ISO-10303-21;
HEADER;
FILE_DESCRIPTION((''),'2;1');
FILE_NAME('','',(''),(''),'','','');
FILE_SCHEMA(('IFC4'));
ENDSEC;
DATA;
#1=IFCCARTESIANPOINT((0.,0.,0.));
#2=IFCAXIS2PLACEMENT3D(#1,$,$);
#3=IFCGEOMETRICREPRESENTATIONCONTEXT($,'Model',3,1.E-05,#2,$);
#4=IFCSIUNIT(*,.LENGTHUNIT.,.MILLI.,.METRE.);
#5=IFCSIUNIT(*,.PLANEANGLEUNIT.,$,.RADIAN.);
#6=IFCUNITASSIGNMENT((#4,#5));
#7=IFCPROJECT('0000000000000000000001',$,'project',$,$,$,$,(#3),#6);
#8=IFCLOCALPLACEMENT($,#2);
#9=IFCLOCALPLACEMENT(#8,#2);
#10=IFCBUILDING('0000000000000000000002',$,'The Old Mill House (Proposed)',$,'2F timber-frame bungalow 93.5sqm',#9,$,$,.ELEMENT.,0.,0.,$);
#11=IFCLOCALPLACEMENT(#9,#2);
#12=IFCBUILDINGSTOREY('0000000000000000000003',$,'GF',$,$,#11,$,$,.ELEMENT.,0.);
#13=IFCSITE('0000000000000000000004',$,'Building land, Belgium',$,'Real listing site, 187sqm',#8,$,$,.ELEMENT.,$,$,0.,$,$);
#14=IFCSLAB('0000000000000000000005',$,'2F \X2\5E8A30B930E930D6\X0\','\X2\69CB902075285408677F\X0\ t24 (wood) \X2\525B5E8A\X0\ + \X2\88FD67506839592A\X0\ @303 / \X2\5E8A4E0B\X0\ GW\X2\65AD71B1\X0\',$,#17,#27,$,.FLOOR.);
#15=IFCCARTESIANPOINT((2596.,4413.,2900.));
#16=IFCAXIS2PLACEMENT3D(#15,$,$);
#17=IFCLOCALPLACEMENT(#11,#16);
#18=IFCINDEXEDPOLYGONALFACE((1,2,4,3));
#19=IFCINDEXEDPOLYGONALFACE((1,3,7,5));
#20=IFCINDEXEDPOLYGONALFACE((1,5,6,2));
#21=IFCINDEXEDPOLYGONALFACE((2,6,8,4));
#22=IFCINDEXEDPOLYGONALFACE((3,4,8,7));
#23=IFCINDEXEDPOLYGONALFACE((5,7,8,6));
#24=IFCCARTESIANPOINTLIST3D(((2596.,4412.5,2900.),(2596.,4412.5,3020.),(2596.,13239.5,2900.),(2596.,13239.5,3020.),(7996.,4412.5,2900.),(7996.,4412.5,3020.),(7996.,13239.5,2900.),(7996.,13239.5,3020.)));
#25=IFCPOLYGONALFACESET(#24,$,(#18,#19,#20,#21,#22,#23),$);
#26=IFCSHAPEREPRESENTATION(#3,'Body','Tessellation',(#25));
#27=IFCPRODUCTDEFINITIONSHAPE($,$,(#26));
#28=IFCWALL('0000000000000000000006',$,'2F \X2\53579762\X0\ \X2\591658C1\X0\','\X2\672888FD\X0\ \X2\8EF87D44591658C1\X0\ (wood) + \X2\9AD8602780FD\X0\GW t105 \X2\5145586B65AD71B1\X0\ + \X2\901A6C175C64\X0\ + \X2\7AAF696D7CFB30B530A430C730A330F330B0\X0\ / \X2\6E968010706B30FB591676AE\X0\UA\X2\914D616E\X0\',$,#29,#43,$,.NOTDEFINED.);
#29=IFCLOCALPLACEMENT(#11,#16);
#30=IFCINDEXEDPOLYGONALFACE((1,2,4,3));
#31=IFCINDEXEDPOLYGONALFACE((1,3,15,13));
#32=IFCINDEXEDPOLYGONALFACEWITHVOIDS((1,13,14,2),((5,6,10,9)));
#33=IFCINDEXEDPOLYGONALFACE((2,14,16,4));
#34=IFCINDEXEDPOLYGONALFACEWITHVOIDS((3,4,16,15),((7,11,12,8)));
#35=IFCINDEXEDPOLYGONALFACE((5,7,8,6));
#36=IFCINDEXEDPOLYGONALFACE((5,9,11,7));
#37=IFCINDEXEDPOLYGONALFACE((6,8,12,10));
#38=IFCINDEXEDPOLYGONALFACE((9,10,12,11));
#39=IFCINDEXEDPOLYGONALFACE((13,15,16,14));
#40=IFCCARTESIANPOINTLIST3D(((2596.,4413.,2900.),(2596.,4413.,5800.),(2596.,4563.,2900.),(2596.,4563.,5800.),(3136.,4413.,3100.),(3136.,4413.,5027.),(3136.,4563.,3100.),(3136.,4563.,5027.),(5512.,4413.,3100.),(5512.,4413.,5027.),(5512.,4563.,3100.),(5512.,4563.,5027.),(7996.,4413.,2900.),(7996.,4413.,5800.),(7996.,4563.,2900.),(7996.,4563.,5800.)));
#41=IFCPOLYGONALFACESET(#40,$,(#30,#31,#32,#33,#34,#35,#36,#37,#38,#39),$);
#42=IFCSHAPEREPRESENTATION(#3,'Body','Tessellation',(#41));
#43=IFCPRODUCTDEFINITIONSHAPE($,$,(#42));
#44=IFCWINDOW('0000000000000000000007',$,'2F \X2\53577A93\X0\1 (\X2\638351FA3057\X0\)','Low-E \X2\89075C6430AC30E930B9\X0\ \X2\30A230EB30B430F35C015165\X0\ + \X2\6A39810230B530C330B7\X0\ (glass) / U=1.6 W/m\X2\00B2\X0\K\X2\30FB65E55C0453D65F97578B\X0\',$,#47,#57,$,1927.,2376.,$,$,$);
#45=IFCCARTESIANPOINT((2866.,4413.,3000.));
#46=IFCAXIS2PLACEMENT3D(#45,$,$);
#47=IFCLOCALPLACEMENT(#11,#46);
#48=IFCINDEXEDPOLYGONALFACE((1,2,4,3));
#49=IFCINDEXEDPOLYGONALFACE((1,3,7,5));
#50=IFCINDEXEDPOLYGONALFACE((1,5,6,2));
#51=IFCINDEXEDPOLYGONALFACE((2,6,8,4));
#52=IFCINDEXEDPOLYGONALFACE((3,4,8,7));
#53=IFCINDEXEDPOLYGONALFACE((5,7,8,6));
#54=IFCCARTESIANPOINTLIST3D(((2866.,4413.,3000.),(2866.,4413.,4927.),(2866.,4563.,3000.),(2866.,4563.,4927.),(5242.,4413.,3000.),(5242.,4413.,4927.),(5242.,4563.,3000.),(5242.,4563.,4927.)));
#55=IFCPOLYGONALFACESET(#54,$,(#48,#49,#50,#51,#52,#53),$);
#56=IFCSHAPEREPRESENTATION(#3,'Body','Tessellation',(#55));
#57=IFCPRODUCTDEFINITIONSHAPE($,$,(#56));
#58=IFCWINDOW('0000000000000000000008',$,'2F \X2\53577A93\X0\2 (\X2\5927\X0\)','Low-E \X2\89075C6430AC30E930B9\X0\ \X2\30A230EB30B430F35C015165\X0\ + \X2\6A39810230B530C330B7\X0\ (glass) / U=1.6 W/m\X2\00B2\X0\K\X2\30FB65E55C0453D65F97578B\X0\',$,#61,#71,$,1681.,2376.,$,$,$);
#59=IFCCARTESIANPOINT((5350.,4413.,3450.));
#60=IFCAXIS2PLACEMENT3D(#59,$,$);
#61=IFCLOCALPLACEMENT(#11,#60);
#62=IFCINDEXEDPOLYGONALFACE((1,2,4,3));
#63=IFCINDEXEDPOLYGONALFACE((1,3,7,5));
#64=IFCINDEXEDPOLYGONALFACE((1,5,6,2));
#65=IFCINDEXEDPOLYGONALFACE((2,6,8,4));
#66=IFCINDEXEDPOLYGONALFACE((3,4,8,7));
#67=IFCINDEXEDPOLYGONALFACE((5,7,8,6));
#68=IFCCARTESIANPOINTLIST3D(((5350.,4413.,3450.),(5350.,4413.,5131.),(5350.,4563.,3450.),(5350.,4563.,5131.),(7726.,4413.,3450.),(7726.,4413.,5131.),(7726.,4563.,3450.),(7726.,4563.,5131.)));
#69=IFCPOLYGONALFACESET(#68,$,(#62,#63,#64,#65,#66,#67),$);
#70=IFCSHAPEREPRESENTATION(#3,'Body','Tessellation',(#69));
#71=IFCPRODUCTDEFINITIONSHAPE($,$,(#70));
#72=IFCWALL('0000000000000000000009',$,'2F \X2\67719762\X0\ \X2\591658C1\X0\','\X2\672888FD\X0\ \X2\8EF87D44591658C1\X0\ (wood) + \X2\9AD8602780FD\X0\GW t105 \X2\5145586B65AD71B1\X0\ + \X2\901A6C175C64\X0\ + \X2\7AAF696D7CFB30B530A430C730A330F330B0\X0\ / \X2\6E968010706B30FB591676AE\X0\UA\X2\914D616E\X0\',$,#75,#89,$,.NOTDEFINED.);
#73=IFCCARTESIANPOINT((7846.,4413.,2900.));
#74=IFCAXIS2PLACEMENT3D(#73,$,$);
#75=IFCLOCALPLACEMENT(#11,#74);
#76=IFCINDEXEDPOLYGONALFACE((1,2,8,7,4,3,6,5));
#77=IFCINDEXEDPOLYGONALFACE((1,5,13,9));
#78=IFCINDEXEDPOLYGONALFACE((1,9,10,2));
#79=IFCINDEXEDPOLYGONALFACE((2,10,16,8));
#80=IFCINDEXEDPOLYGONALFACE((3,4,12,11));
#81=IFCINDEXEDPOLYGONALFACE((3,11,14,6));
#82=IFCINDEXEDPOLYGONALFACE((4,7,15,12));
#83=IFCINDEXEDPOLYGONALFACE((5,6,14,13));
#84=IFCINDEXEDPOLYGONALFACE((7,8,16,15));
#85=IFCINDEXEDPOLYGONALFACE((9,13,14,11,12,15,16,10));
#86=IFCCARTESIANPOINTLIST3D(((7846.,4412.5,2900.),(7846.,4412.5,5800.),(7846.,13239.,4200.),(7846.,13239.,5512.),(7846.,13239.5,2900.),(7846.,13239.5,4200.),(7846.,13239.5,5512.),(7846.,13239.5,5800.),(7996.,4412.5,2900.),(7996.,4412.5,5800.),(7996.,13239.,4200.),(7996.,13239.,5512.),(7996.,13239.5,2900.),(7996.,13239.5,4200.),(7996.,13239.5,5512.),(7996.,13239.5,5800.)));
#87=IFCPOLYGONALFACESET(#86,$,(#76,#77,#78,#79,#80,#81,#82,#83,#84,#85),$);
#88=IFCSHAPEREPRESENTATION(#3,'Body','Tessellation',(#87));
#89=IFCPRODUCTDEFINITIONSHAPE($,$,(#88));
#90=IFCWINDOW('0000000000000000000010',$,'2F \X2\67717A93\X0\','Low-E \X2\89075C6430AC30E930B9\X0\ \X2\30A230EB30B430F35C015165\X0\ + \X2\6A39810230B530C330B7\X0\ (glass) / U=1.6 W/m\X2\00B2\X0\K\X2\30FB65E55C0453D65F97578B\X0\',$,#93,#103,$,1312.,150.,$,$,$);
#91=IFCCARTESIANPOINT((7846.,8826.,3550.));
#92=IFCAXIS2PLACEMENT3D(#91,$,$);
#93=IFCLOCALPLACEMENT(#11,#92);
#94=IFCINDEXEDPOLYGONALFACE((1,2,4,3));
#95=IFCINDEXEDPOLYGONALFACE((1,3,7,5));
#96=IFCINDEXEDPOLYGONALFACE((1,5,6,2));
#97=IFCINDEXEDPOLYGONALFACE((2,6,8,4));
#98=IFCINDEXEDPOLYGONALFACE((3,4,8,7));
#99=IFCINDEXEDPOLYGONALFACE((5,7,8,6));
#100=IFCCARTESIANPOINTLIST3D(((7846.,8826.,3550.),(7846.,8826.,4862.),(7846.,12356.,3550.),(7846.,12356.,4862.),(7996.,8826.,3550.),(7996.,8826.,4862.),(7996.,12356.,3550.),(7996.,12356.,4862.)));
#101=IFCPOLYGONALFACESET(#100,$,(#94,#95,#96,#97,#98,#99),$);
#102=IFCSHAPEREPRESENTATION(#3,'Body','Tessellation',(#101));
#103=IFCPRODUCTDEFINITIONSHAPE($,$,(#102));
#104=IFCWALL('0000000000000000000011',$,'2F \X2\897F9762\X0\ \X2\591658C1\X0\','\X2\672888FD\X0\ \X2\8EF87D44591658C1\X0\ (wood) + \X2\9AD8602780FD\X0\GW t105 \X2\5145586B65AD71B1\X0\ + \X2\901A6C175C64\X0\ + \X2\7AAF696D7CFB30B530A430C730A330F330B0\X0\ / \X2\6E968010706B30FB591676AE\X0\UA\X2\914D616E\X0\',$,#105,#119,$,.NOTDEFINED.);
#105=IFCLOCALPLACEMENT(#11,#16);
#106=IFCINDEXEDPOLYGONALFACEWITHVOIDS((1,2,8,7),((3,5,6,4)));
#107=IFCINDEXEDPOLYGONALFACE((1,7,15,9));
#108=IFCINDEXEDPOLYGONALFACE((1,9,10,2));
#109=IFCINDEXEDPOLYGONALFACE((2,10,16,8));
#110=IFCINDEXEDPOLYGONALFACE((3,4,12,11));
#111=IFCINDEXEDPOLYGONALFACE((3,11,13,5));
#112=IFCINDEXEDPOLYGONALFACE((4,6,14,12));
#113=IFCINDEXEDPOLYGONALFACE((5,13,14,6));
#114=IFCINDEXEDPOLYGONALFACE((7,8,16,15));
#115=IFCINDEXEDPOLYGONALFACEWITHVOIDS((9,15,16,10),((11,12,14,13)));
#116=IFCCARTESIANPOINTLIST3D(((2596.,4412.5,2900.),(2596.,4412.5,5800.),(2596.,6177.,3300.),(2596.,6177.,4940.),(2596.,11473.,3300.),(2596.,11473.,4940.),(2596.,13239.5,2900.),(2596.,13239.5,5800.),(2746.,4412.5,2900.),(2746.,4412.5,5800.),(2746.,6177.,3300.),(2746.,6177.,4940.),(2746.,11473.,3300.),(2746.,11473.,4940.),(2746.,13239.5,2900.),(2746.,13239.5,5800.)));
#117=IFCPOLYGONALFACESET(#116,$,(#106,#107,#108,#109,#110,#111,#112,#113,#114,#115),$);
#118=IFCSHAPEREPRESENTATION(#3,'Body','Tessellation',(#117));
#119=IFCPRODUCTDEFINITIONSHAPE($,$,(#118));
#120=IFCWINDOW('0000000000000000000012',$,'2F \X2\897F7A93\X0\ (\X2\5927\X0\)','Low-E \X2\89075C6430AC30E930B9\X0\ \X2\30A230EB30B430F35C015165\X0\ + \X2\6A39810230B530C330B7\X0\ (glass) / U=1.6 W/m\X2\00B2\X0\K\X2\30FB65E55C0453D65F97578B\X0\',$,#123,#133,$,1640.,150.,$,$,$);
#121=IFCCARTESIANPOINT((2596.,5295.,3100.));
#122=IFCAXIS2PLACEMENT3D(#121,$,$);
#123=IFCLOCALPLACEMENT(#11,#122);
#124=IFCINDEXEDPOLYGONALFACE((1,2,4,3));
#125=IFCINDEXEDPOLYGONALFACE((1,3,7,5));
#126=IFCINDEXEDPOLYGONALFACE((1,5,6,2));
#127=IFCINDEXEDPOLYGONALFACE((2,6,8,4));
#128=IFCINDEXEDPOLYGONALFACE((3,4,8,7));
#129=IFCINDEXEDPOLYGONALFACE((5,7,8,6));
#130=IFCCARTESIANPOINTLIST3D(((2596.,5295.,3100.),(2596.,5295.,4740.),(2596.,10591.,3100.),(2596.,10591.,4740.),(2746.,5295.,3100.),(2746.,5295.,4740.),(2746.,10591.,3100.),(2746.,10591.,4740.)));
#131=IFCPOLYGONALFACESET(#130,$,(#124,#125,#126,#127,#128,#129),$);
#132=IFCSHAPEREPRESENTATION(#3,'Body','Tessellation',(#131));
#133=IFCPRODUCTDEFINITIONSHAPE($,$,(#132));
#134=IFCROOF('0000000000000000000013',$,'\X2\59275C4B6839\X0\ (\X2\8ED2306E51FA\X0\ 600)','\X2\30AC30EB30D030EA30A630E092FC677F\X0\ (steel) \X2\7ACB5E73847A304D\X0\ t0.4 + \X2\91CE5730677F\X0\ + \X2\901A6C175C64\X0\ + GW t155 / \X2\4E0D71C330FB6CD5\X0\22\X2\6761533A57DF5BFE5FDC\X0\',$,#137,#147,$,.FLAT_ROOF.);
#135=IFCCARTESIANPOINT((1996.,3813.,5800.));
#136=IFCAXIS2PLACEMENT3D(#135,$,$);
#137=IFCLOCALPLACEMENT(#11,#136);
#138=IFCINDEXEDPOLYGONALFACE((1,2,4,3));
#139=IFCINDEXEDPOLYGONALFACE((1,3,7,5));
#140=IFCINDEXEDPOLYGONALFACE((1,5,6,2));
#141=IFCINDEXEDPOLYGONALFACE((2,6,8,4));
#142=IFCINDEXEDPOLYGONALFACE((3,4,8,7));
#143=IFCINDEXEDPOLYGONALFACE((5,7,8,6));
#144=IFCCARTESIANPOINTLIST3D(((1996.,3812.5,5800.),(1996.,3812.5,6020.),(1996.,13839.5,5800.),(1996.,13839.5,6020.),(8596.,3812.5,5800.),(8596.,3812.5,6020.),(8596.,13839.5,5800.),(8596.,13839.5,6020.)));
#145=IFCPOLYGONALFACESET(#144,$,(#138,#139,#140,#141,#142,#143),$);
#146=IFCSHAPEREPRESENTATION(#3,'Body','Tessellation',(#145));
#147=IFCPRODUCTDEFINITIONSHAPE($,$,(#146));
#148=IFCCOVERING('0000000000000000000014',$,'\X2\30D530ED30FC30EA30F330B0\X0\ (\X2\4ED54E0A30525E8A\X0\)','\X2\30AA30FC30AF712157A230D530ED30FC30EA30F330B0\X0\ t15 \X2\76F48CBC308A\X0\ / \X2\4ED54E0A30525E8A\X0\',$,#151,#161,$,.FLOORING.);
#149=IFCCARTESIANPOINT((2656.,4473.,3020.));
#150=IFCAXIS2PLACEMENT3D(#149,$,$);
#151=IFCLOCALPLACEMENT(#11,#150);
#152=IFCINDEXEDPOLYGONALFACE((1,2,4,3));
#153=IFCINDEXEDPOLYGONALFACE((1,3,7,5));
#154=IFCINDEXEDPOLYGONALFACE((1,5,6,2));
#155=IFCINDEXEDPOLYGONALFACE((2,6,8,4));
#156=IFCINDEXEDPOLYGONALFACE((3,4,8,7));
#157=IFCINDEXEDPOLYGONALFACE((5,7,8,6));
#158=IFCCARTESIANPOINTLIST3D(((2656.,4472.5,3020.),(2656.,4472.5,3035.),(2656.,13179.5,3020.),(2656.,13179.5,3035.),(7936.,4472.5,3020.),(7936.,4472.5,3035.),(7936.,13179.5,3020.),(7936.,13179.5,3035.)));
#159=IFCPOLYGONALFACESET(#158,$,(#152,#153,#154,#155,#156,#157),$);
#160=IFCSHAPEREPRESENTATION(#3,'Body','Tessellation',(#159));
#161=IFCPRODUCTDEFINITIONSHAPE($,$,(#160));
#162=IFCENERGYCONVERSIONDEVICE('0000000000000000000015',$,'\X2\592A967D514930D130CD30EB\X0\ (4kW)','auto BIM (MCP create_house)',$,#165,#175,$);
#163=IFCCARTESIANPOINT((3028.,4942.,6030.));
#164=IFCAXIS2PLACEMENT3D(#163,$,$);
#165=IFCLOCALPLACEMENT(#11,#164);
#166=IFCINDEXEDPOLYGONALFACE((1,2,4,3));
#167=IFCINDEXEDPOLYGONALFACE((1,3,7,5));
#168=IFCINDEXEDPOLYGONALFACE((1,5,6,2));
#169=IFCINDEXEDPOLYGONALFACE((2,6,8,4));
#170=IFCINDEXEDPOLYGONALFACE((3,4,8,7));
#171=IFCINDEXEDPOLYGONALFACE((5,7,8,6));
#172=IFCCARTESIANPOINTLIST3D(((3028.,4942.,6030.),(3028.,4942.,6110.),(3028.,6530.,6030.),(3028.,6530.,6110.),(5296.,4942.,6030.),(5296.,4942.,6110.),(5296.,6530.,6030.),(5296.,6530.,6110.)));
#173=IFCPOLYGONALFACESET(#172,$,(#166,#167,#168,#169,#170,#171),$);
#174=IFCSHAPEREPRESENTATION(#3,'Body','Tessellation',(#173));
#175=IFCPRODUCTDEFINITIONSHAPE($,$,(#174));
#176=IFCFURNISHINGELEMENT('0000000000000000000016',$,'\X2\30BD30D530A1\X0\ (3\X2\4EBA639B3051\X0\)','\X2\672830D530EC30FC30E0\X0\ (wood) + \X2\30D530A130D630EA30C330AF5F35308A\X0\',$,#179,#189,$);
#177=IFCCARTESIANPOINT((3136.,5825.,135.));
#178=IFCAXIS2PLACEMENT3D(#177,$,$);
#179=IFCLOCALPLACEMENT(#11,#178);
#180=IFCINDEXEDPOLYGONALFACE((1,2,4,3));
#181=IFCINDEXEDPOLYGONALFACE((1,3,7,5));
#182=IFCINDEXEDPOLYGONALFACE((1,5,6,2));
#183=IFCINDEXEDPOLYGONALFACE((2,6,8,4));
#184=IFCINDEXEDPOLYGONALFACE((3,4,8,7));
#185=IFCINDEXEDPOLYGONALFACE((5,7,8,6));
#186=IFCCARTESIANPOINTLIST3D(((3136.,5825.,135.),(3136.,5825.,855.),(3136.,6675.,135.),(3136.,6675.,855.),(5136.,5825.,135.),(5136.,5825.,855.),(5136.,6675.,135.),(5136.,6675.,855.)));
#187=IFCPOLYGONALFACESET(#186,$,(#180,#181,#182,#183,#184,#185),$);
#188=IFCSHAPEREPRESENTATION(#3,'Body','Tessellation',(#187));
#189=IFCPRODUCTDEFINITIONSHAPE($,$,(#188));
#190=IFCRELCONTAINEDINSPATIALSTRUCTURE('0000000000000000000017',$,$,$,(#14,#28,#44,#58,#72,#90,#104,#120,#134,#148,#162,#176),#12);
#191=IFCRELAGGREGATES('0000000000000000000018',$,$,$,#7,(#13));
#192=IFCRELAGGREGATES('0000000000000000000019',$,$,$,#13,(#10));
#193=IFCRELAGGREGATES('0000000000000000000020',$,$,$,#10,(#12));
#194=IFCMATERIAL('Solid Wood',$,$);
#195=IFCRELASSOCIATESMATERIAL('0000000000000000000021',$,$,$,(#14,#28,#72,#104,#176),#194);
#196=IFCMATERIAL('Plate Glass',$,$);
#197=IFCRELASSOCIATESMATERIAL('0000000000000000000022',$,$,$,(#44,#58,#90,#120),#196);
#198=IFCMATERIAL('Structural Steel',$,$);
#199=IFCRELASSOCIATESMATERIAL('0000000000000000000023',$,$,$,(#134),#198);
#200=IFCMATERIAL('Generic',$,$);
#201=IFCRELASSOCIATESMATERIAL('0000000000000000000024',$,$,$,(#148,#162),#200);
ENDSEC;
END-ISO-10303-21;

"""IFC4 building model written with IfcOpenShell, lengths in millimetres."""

from ifc_helpers import new_model, si_unit, frame, frame_2d, origin, place, context, project, spatial, rectangle, extrude, material, element, fill, save


model = new_model("IFC4")

# Units and contexts
model_context = context("Model", 3, precision=1e-05, world=origin())
ifc_project = project(units=[si_unit("LENGTHUNIT", "METRE", prefix="MILLI"), si_unit("PLANEANGLEUNIT", "RADIAN")], contexts=[model_context])

# Site, building, storey
site_placement = place(None, origin())
site = spatial("IfcSite", under=ifc_project, at=site_placement, Name="Building land, Belgium", ObjectType="Real listing site, 187sqm", CompositionType="ELEMENT", RefElevation=0.0)
building_placement = place(site_placement, origin())
building = spatial("IfcBuilding", under=site, at=building_placement, Name="The Old Mill House (Proposed)", ObjectType="2F timber-frame bungalow 93.5sqm", CompositionType="ELEMENT", ElevationOfRefHeight=0.0, ElevationOfTerrain=0.0)
storey_placement = place(building_placement, origin())
storey = spatial("IfcBuildingStorey", under=building, at=storey_placement, Name="GF", CompositionType="ELEMENT", Elevation=0.0)

# Slab
ifc_material_1 = material(Name="Solid Wood")
slab_placement = place(storey_placement, frame((2596.0, 4413.0, 2900.0)))
element("IfcSlab", 1, at=slab_placement, inside=storey, material=ifc_material_1, Name="2F 床スラブ", Description="構造用合板 t24 (wood) 剛床 + 製材根太 @303 / 床下 GW断熱", PredefinedType="FLOOR", context=model_context, shape_type="SweptSolid", body=[
    extrude(rectangle(XDim=5400.0, YDim=8827.0, at=frame_2d((2700.0, 4413.0))), frame((2596.0, 4413.0, 2900.0)), (0.0, 0.0, 1.0), 120.0),
])

# Wall, openings, windows
wall_1_placement = place(storey_placement, frame((2596.0, 4413.0, 2900.0)))
wall_1 = element("IfcWall", 2, at=wall_1_placement, inside=storey, material=ifc_material_1, Name="2F 南面 外壁", Description="木製 軸組外壁 (wood) + 高性能GW t105 充填断熱 + 通気層 + 窯業系サイディング / 準耐火・外皮UA配慮", PredefinedType="NOTDEFINED", context=model_context, shape_type="SweptSolid", body=[
    extrude(rectangle(XDim=5400.0, YDim=150.0, at=frame_2d((2700.0, 75.0))), frame((2596.0, 4413.0, 2900.0)), (0.0, 0.0, 1.0), 2900.0),
])
opening_1_placement = place(storey_placement, frame((2866.0, 4413.0, 3000.0)))
opening_1 = element("IfcOpeningElement", 3, at=opening_1_placement, cuts=wall_1, PredefinedType="NOTDEFINED", context=model_context, shape_type="SweptSolid", body=[
    extrude(rectangle(XDim=2376.0, YDim=150.0, at=frame_2d((1188.0, 75.0))), frame((2866.0, 4413.0, 3000.0)), (0.0, 0.0, 1.0), 1927.0),
])
opening_2_placement = place(storey_placement, frame((5350.0, 4413.0, 3450.0)))
opening_2 = element("IfcOpeningElement", 4, at=opening_2_placement, cuts=wall_1, PredefinedType="NOTDEFINED", context=model_context, shape_type="SweptSolid", body=[
    extrude(rectangle(XDim=2376.0, YDim=150.0, at=frame_2d((1188.0, 75.0))), frame((5350.0, 4413.0, 3450.0)), (0.0, 0.0, 1.0), 1681.0),
])
ifc_material_2 = material(Name="Plate Glass")
window_1_placement = place(storey_placement, frame((2866.0, 4413.0, 3000.0)))
window_1 = element("IfcWindow", 5, at=window_1_placement, inside=storey, material=ifc_material_2, Name="2F 南窓1 (掃出し)", Description="Low-E 複層ガラス アルゴン封入 + 樹脂サッシ (glass) / U=1.6 W/m²K・日射取得型", OverallHeight=1927.0, OverallWidth=2376.0, context=model_context, shape_type="SweptSolid", body=[
    extrude(rectangle(XDim=2376.0, YDim=150.0, at=frame_2d((1188.0, 75.0))), frame((2866.0, 4413.0, 3000.0)), (0.0, 0.0, 1.0), 1927.0),
])
fill(opening_1, window_1)
window_2_placement = place(storey_placement, frame((5350.0, 4413.0, 3450.0)))
window_2 = element("IfcWindow", 6, at=window_2_placement, inside=storey, material=ifc_material_2, Name="2F 南窓2 (大)", Description="Low-E 複層ガラス アルゴン封入 + 樹脂サッシ (glass) / U=1.6 W/m²K・日射取得型", OverallHeight=1681.0, OverallWidth=2376.0, context=model_context, shape_type="SweptSolid", body=[
    extrude(rectangle(XDim=2376.0, YDim=150.0, at=frame_2d((1188.0, 75.0))), frame((5350.0, 4413.0, 3450.0)), (0.0, 0.0, 1.0), 1681.0),
])
fill(opening_2, window_2)

# Walls, openings, windows
wall_2_placement = place(storey_placement, frame((7846.0, 4413.0, 2900.0)))
wall_2 = element("IfcWall", 7, at=wall_2_placement, inside=storey, material=ifc_material_1, Name="2F 東面 外壁", Description="木製 軸組外壁 (wood) + 高性能GW t105 充填断熱 + 通気層 + 窯業系サイディング / 準耐火・外皮UA配慮", PredefinedType="NOTDEFINED", context=model_context, shape_type="SweptSolid", body=[
    extrude(rectangle(XDim=150.0, YDim=8827.0, at=frame_2d((75.0, 4413.0))), frame((7846.0, 4413.0, 2900.0)), (0.0, 0.0, 1.0), 2900.0),
])
opening_3_placement = place(storey_placement, frame((7846.0, 8826.0, 3550.0)))
opening_3 = element("IfcOpeningElement", 8, at=opening_3_placement, cuts=wall_2, PredefinedType="NOTDEFINED", context=model_context, shape_type="SweptSolid", body=[
    extrude(rectangle(XDim=150.0, YDim=3530.0, at=frame_2d((75.0, 1765.0))), frame((7846.0, 8826.0, 3550.0)), (0.0, 0.0, 1.0), 1312.0),
])
window_3_placement = place(storey_placement, frame((7846.0, 8826.0, 3550.0)))
window_3 = element("IfcWindow", 9, at=window_3_placement, inside=storey, material=ifc_material_2, Name="2F 東窓", Description="Low-E 複層ガラス アルゴン封入 + 樹脂サッシ (glass) / U=1.6 W/m²K・日射取得型", OverallHeight=1312.0, OverallWidth=150.0, context=model_context, shape_type="SweptSolid", body=[
    extrude(rectangle(XDim=150.0, YDim=3530.0, at=frame_2d((75.0, 1765.0))), frame((7846.0, 8826.0, 3550.0)), (0.0, 0.0, 1.0), 1312.0),
])
fill(opening_3, window_3)
wall_3_placement = place(storey_placement, frame((2596.0, 4413.0, 2900.0)))
wall_3 = element("IfcWall", 10, at=wall_3_placement, inside=storey, material=ifc_material_1, Name="2F 西面 外壁", Description="木製 軸組外壁 (wood) + 高性能GW t105 充填断熱 + 通気層 + 窯業系サイディング / 準耐火・外皮UA配慮", PredefinedType="NOTDEFINED", context=model_context, shape_type="SweptSolid", body=[
    extrude(rectangle(XDim=150.0, YDim=8827.0, at=frame_2d((75.0, 4413.0))), frame((2596.0, 4413.0, 2900.0)), (0.0, 0.0, 1.0), 2900.0),
])
opening_4_placement = place(storey_placement, frame((2596.0, 5295.0, 3100.0)))
opening_4 = element("IfcOpeningElement", 11, at=opening_4_placement, cuts=wall_3, PredefinedType="NOTDEFINED", context=model_context, shape_type="SweptSolid", body=[
    extrude(rectangle(XDim=150.0, YDim=5296.0, at=frame_2d((75.0, 2648.0))), frame((2596.0, 5295.0, 3100.0)), (0.0, 0.0, 1.0), 1640.0),
])
window_4_placement = place(storey_placement, frame((2596.0, 5295.0, 3100.0)))
window_4 = element("IfcWindow", 12, at=window_4_placement, inside=storey, material=ifc_material_2, Name="2F 西窓 (大)", Description="Low-E 複層ガラス アルゴン封入 + 樹脂サッシ (glass) / U=1.6 W/m²K・日射取得型", OverallHeight=1640.0, OverallWidth=150.0, context=model_context, shape_type="SweptSolid", body=[
    extrude(rectangle(XDim=150.0, YDim=5296.0, at=frame_2d((75.0, 2648.0))), frame((2596.0, 5295.0, 3100.0)), (0.0, 0.0, 1.0), 1640.0),
])
fill(opening_4, window_4)

# Roof
ifc_material_3 = material(Name="Structural Steel")
roof_placement = place(storey_placement, frame((1996.0, 3813.0, 5800.0)))
element("IfcRoof", 13, at=roof_placement, inside=storey, material=ifc_material_3, Name="大屋根 (軒の出 600)", Description="ガルバリウム鋼板 (steel) 立平葺き t0.4 + 野地板 + 通気層 + GW t155 / 不燃・法22条区域対応", PredefinedType="FLAT_ROOF", context=model_context, shape_type="SweptSolid", body=[
    extrude(rectangle(XDim=6600.0, YDim=10027.0, at=frame_2d((3300.0, 5013.0))), frame((1996.0, 3813.0, 5800.0)), (0.0, 0.0, 1.0), 220.0),
])

# Covering
ifc_material_4 = material(Name="Generic")
covering_placement = place(storey_placement, frame((2656.0, 4473.0, 3020.0)))
element("IfcCovering", 14, at=covering_placement, inside=storey, material=ifc_material_4, Name="フローリング (仕上げ床)", Description="オーク無垢フローリング t15 直貼り / 仕上げ床", PredefinedType="FLOORING", context=model_context, shape_type="SweptSolid", body=[
    extrude(rectangle(XDim=5280.0, YDim=8707.0, at=frame_2d((2640.0, 4353.0))), frame((2656.0, 4473.0, 3020.0)), (0.0, 0.0, 1.0), 15.0),
])

# Energy conversion device
energy_conversion_device_placement = place(storey_placement, frame((3028.0, 4942.0, 6030.0)))
element("IfcEnergyConversionDevice", 15, at=energy_conversion_device_placement, inside=storey, material=ifc_material_4, Name="太陽光パネル (4kW)", Description="auto BIM (MCP create_house)", context=model_context, shape_type="SweptSolid", body=[
    extrude(rectangle(XDim=2268.0, YDim=1588.0, at=frame_2d((1134.0, 794.0))), frame((3028.0, 4942.0, 6030.0)), (0.0, 0.0, 1.0), 80.0),
])

# Furnishing element
furnishing_1_placement = place(storey_placement, frame((3136.0, 5825.0, 135.0)))
element("IfcFurnishingElement", 16, at=furnishing_1_placement, inside=storey, material=ifc_material_1, Name="ソファ (3人掛け)", Description="木フレーム (wood) + ファブリック張り", context=model_context, shape_type="SweptSolid", body=[
    extrude(rectangle(XDim=2000.0, YDim=850.0, at=frame_2d((1000.0, 425.0))), frame((3136.0, 5825.0, 135.0)), (0.0, 0.0, 1.0), 720.0),
])

save(model, "model.ifc")
